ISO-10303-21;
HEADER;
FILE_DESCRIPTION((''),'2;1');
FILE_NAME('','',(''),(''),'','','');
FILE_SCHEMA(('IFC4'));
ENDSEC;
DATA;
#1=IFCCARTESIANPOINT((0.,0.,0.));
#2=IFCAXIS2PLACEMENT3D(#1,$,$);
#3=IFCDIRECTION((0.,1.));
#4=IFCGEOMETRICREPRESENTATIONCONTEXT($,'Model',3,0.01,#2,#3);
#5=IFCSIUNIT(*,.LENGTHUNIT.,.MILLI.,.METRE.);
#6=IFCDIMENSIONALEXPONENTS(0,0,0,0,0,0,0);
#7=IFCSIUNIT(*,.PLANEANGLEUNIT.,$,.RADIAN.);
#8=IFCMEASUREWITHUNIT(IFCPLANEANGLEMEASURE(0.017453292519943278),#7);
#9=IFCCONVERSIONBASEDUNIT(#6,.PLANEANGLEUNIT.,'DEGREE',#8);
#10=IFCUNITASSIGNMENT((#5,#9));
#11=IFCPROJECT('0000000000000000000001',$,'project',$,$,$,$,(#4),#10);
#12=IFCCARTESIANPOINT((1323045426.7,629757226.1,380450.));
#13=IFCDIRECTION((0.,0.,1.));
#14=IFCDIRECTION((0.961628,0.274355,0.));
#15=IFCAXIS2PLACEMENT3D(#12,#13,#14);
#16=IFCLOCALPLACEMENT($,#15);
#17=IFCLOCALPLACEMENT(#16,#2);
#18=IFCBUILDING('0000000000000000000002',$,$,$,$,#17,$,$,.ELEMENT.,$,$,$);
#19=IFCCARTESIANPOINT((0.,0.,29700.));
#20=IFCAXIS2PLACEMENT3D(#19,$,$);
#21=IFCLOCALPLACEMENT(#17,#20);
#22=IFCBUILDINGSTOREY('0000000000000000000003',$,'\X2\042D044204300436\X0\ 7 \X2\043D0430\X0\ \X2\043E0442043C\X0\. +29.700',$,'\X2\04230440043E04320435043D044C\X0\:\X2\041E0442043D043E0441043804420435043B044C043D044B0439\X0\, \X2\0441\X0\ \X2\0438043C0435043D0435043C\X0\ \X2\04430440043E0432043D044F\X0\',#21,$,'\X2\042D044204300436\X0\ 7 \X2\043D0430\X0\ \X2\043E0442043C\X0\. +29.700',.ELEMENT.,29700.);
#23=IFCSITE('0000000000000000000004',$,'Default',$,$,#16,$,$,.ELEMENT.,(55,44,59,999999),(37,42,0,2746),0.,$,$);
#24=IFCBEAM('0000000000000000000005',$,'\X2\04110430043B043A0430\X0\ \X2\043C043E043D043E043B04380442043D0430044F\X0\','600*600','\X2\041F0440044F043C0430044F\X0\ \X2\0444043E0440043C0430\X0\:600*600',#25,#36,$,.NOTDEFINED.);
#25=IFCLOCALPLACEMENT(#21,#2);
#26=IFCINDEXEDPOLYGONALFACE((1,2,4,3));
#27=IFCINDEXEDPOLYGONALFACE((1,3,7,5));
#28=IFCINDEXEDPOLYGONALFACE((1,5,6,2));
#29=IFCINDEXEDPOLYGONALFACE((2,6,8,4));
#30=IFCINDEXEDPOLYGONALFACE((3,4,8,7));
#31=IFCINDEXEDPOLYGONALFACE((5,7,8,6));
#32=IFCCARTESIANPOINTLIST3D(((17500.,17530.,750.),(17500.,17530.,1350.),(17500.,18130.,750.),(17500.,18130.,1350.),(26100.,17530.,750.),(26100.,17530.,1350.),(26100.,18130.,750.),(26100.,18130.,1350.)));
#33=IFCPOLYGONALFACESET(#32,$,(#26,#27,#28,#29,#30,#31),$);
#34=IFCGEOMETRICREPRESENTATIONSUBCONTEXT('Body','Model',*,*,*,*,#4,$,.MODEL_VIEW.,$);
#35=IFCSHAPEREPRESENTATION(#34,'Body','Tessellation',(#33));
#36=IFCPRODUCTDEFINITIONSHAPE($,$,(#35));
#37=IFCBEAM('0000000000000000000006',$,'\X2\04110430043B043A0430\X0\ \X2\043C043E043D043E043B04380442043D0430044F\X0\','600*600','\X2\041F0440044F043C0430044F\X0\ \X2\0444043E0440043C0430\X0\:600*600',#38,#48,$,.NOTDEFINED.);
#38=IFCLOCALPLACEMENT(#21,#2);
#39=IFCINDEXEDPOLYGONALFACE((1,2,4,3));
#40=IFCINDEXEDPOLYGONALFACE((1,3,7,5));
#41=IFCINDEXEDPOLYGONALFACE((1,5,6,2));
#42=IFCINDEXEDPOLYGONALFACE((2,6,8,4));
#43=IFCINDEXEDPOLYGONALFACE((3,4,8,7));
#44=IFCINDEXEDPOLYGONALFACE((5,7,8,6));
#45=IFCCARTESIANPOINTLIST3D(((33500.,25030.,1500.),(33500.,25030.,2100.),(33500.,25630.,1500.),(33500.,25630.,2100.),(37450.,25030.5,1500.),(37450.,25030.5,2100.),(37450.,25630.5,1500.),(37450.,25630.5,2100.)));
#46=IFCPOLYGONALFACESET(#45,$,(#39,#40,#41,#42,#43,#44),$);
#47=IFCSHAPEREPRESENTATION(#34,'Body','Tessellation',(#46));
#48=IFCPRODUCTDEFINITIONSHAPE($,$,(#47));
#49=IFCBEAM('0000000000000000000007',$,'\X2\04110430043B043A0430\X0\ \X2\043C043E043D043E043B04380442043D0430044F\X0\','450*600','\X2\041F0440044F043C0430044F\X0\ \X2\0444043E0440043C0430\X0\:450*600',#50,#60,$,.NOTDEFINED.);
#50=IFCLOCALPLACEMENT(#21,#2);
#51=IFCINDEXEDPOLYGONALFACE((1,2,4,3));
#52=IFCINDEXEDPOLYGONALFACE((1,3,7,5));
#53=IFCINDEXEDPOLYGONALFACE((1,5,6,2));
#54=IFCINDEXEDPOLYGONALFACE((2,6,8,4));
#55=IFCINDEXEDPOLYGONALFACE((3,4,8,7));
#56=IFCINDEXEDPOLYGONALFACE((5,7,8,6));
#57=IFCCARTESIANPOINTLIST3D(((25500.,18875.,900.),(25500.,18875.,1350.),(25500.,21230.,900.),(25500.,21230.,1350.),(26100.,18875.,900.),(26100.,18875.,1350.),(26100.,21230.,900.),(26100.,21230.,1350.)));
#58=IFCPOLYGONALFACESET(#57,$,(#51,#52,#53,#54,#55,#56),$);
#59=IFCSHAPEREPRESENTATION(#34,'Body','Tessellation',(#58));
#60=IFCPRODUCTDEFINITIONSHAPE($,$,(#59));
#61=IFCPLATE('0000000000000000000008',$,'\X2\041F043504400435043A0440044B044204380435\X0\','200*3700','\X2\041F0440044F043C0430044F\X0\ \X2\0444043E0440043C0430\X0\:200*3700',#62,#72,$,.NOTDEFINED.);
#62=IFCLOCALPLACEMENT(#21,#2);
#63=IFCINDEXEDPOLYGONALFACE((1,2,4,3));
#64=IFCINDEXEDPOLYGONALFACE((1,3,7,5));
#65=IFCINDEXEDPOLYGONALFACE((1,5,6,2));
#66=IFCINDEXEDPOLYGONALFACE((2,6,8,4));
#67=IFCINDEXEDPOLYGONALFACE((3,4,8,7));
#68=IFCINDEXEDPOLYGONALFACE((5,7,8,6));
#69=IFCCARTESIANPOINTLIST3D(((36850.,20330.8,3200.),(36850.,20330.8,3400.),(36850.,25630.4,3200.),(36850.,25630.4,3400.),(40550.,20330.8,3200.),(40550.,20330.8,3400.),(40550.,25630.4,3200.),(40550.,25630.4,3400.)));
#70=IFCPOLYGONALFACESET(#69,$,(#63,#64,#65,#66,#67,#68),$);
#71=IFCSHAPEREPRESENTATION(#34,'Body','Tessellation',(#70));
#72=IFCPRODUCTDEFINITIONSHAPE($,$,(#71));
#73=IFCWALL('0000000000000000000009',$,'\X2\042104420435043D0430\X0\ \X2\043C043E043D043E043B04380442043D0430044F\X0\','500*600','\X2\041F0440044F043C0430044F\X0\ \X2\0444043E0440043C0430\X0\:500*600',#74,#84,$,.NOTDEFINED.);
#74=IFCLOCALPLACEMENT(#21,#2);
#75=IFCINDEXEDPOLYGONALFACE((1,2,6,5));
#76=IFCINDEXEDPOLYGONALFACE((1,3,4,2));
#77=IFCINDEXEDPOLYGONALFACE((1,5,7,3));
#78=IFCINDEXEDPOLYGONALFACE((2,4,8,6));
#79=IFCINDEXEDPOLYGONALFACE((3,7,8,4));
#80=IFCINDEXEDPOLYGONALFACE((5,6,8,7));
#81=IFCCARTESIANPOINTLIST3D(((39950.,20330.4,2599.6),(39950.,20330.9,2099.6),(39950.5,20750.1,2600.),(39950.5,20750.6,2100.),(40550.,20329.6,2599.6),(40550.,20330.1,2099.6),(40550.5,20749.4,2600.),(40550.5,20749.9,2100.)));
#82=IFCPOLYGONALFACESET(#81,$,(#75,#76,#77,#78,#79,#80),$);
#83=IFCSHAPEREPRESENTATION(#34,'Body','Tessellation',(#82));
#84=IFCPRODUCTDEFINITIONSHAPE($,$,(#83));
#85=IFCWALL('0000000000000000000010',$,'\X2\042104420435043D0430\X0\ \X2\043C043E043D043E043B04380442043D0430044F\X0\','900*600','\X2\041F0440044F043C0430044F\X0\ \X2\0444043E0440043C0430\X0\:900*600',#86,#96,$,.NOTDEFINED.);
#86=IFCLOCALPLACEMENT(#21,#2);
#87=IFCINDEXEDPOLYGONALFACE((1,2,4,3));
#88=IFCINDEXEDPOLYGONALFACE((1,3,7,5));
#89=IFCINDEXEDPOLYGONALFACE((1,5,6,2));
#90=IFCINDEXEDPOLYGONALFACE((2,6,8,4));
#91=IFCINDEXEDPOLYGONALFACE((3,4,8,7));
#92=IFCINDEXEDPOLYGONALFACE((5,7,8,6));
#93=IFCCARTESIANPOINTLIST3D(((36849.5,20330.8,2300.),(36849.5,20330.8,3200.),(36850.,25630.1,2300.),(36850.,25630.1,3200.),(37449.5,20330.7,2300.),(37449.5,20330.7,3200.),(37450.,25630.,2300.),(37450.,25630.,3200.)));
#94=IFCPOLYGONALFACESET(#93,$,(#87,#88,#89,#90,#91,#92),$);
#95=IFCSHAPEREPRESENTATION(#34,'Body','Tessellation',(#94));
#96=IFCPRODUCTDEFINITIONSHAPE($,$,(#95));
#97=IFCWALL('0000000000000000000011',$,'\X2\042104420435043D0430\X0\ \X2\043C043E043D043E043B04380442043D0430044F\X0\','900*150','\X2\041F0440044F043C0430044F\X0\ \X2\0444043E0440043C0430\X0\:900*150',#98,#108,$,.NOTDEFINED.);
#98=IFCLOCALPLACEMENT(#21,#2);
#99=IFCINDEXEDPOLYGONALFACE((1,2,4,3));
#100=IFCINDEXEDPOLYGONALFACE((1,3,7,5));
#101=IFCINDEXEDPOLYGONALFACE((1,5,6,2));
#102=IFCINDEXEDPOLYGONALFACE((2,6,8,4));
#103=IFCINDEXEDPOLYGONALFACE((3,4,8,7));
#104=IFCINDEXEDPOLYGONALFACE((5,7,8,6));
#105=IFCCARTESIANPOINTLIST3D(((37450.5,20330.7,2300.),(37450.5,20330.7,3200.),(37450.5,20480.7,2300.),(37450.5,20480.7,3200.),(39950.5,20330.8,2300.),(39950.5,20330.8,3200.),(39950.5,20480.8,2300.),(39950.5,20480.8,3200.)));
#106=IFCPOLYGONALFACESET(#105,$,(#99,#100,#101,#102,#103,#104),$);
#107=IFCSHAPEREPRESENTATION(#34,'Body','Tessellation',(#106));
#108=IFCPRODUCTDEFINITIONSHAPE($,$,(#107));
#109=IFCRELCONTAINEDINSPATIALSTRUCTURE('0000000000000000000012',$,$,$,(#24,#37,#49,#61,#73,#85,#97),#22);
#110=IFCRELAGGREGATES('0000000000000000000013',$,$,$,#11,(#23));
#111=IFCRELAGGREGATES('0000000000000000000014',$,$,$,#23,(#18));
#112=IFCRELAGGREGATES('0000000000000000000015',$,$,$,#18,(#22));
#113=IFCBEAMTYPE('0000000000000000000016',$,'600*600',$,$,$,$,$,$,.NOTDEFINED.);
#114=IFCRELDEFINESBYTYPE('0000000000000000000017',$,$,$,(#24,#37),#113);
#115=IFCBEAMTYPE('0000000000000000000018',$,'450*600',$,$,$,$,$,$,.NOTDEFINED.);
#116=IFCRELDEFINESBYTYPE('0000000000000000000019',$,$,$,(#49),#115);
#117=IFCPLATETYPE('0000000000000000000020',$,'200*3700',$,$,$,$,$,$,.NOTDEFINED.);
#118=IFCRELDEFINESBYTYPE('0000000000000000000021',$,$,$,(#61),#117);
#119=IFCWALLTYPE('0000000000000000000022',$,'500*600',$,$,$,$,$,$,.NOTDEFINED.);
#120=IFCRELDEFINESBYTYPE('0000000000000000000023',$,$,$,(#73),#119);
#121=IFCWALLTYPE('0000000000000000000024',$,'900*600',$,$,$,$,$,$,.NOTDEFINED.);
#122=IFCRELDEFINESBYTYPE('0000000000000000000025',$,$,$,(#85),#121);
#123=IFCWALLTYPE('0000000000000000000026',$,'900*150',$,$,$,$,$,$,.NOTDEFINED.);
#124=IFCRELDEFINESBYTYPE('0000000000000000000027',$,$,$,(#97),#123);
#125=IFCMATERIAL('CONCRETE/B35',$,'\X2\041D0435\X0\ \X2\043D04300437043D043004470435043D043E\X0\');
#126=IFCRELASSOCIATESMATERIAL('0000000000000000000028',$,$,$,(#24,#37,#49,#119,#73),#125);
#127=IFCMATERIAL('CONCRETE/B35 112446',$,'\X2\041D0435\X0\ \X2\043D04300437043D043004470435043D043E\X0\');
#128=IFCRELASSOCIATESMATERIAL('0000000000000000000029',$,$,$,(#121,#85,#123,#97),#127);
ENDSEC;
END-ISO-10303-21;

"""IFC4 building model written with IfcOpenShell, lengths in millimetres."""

from ifc_helpers import new_model, entity, si_unit, converted_unit, direction, frame, origin, place, context, subcontext, project, spatial, indexed_curve, outline, extrude, material, type_object, element, save


model = new_model("IFC4")

# Units and contexts
model_context = context("Model", 3, precision=0.01, world=origin(), true_north=direction((0.0, 1.0)))
body_context = subcontext(model_context, "Body", "Model", "MODEL_VIEW")
ifc_project = project(units=[si_unit("LENGTHUNIT", "METRE", prefix="MILLI"), converted_unit("PLANEANGLEUNIT", "DEGREE", entity("IfcPlaneAngleMeasure", 0.017453292519943278), si_unit("PLANEANGLEUNIT", "RADIAN"), dimensions=[0, 0, 0, 0, 0, 0, 0])], contexts=[model_context])

# Site, building, storey
site_placement = place(None, frame((1323045426.7, 629757226.1, 380450.0), z_axis=(0.0, 0.0, 1.0), x_axis=(0.961628, 0.274355, 0.0)))
site = spatial("IfcSite", under=ifc_project, at=site_placement, Name="Default", CompositionType="ELEMENT", RefLatitude=(55, 44, 59, 999999), RefLongitude=(37, 42, 0, 2746), RefElevation=0.0)
building_placement = place(site_placement, origin())
building = spatial("IfcBuilding", under=site, at=building_placement, CompositionType="ELEMENT")
storey_placement = place(building_placement, frame((0.0, 0.0, 29700.0)))
storey = spatial("IfcBuildingStorey", under=building, at=storey_placement, Name="Этаж 7 на отм. +29.700", ObjectType="Уровень:Относительный, с именем уровня", LongName="Этаж 7 на отм. +29.700", CompositionType="ELEMENT", Elevation=29700.0)

# Beams
ifc_material_1 = material(Name="CONCRETE/B35", Category="Не назначено")
beam_type_1 = type_object("IfcBeamType", Name="600*600", PredefinedType="NOTDEFINED")
beam_1_placement = place(storey_placement, origin())
element("IfcBeam", 1, at=beam_1_placement, inside=storey, type_object=beam_type_1, material=ifc_material_1, Name="Балка монолитная", Description="600*600", ObjectType="Прямая форма:600*600", PredefinedType="NOTDEFINED", context=body_context, shape_type="SweptSolid", body=[
    extrude(outline(indexed_curve([(-300.0, -300.0), (300.0, -300.0), (300.0, 300.0), (-300.0, 300.0), (-300.0, -300.0)], self_intersect=False)), frame((17500.0, 17830.0, 1050.0), z_axis=(1.0, 0.0, 0.0), x_axis=(0.0, 0.0, 1.0)), (0.0, 0.0, 1.0), 8600.0),
])
beam_2_placement = place(storey_placement, origin())
element("IfcBeam", 2, at=beam_2_placement, inside=storey, type_object=beam_type_1, material=ifc_material_1, Name="Балка монолитная", Description="600*600", ObjectType="Прямая форма:600*600", PredefinedType="NOTDEFINED", context=body_context, shape_type="SweptSolid", body=[
    extrude(outline(indexed_curve([(-300.0, -300.0), (300.0, -300.0), (300.0, 300.0), (-300.0, 300.0), (-300.0, -300.0)], self_intersect=False)), frame((33500.0, 25330.0, 1800.0), z_axis=(1.0, 0.000127, 0.0), x_axis=(-0.000127, 1.0, 0.0)), (0.0, 0.0, 1.0), 3950.0),
])
beam_type_2 = type_object("IfcBeamType", Name="450*600", PredefinedType="NOTDEFINED")
beam_3_placement = place(storey_placement, origin())
element("IfcBeam", 3, at=beam_3_placement, inside=storey, type_object=beam_type_2, material=ifc_material_1, Name="Балка монолитная", Description="450*600", ObjectType="Прямая форма:450*600", PredefinedType="NOTDEFINED", context=body_context, shape_type="SweptSolid", body=[
    extrude(outline(indexed_curve([(-1177.5, -225.0), (1177.5, -225.0), (1177.5, 225.0), (-1177.5, 225.0), (-1177.5, -225.0)], self_intersect=False)), frame((25500.0, 20052.5, 1125.0), z_axis=(1.0, 0.000001, 0.0), x_axis=(-0.000001, 1.0, 0.0)), (0.0, 0.0, 1.0), 600.0),
])

# Plate
plate_type_1 = type_object("IfcPlateType", Name="200*3700", PredefinedType="NOTDEFINED")
plate_1_placement = place(storey_placement, origin())
element("IfcPlate", 4, at=plate_1_placement, inside=storey, type_object=plate_type_1, Name="Перекрытие", Description="200*3700", ObjectType="Прямая форма:200*3700", PredefinedType="NOTDEFINED", context=body_context, shape_type="SweptSolid", body=[
    extrude(outline(indexed_curve([(-2649.8, -1850.0), (2649.8, -1850.0), (2649.8, 1850.0), (-2649.8, 1850.0), (-2649.8, -1850.0)], self_intersect=False)), frame((38700.0, 22980.6, 3200.0), z_axis=(0.0, 0.0, 1.0), x_axis=(-0.000001, 1.0, 0.0)), (0.0, 0.0, 1.0), 200.0),
])

# Walls
wall_type_1 = type_object("IfcWallType", Name="500*600", PredefinedType="NOTDEFINED", material=ifc_material_1)
wall_1_placement = place(storey_placement, frame((39950.0, 20329.6, 2099.6)))
element("IfcWall", 5, at=wall_1_placement, inside=storey, type_object=wall_type_1, material=ifc_material_1, Name="Стена монолитная", Description="500*600", ObjectType="Прямая форма:500*600", PredefinedType="NOTDEFINED", context=body_context, shape_type="SweptSolid", body=[
    extrude(outline(indexed_curve([(-300.0, -209.9), (300.0, -209.9), (300.0, 209.9), (-300.0, 209.9), (-300.0, -209.9)], self_intersect=False)), frame((300.3, 210.7, 0.2), z_axis=(-0.000001, -0.000979, 1.0), x_axis=(0.999999, -0.001258, 0.0)), (0.0, 0.0, 1.0), 500.0),
])
ifc_material_2 = material(Name="CONCRETE/B35 112446", Category="Не назначено")
wall_type_2 = type_object("IfcWallType", Name="900*600", PredefinedType="NOTDEFINED", material=ifc_material_2)
wall_2_placement = place(storey_placement, frame((36849.5, 20330.7, 2300.0), z_axis=(0.0, 0.0, 1.0), x_axis=(0.0, 1.0, 0.0)))
element("IfcWall", 6, at=wall_2_placement, inside=storey, type_object=wall_type_2, material=ifc_material_2, Name="Стена монолитная", Description="900*600", ObjectType="Прямая форма:900*600", PredefinedType="NOTDEFINED", context=body_context, shape_type="SweptSolid", body=[
    extrude(outline(indexed_curve([(-300.0, -2649.6), (300.0, -2649.6), (300.0, 2649.6), (-300.0, 2649.6), (-300.0, -2649.6)], self_intersect=False)), frame((2649.7, -300.2, 0.0), z_axis=(0.0, 0.0, 1.0), x_axis=(-0.000087, -1.0, 0.0)), (0.0, 0.0, 1.0), 900.0),
])
wall_type_3 = type_object("IfcWallType", Name="900*150", PredefinedType="NOTDEFINED", material=ifc_material_2)
wall_3_placement = place(storey_placement, frame((37450.5, 20330.7, 2300.0)))
element("IfcWall", 7, at=wall_3_placement, inside=storey, type_object=wall_type_3, material=ifc_material_2, Name="Стена монолитная", Description="900*150", ObjectType="Прямая форма:900*150", PredefinedType="NOTDEFINED", context=body_context, shape_type="SweptSolid", body=[
    extrude(outline(indexed_curve([(-75.0, -1250.0), (75.0, -1250.0), (75.0, 1250.0), (-75.0, 1250.0), (-75.0, -1250.0)], self_intersect=False)), frame((1250.0, 75.0, 0.0), z_axis=(0.0, 0.0, 1.0), x_axis=(-0.000021, 1.0, 0.0)), (0.0, 0.0, 1.0), 900.0),
])

save(model, "model.ifc")
